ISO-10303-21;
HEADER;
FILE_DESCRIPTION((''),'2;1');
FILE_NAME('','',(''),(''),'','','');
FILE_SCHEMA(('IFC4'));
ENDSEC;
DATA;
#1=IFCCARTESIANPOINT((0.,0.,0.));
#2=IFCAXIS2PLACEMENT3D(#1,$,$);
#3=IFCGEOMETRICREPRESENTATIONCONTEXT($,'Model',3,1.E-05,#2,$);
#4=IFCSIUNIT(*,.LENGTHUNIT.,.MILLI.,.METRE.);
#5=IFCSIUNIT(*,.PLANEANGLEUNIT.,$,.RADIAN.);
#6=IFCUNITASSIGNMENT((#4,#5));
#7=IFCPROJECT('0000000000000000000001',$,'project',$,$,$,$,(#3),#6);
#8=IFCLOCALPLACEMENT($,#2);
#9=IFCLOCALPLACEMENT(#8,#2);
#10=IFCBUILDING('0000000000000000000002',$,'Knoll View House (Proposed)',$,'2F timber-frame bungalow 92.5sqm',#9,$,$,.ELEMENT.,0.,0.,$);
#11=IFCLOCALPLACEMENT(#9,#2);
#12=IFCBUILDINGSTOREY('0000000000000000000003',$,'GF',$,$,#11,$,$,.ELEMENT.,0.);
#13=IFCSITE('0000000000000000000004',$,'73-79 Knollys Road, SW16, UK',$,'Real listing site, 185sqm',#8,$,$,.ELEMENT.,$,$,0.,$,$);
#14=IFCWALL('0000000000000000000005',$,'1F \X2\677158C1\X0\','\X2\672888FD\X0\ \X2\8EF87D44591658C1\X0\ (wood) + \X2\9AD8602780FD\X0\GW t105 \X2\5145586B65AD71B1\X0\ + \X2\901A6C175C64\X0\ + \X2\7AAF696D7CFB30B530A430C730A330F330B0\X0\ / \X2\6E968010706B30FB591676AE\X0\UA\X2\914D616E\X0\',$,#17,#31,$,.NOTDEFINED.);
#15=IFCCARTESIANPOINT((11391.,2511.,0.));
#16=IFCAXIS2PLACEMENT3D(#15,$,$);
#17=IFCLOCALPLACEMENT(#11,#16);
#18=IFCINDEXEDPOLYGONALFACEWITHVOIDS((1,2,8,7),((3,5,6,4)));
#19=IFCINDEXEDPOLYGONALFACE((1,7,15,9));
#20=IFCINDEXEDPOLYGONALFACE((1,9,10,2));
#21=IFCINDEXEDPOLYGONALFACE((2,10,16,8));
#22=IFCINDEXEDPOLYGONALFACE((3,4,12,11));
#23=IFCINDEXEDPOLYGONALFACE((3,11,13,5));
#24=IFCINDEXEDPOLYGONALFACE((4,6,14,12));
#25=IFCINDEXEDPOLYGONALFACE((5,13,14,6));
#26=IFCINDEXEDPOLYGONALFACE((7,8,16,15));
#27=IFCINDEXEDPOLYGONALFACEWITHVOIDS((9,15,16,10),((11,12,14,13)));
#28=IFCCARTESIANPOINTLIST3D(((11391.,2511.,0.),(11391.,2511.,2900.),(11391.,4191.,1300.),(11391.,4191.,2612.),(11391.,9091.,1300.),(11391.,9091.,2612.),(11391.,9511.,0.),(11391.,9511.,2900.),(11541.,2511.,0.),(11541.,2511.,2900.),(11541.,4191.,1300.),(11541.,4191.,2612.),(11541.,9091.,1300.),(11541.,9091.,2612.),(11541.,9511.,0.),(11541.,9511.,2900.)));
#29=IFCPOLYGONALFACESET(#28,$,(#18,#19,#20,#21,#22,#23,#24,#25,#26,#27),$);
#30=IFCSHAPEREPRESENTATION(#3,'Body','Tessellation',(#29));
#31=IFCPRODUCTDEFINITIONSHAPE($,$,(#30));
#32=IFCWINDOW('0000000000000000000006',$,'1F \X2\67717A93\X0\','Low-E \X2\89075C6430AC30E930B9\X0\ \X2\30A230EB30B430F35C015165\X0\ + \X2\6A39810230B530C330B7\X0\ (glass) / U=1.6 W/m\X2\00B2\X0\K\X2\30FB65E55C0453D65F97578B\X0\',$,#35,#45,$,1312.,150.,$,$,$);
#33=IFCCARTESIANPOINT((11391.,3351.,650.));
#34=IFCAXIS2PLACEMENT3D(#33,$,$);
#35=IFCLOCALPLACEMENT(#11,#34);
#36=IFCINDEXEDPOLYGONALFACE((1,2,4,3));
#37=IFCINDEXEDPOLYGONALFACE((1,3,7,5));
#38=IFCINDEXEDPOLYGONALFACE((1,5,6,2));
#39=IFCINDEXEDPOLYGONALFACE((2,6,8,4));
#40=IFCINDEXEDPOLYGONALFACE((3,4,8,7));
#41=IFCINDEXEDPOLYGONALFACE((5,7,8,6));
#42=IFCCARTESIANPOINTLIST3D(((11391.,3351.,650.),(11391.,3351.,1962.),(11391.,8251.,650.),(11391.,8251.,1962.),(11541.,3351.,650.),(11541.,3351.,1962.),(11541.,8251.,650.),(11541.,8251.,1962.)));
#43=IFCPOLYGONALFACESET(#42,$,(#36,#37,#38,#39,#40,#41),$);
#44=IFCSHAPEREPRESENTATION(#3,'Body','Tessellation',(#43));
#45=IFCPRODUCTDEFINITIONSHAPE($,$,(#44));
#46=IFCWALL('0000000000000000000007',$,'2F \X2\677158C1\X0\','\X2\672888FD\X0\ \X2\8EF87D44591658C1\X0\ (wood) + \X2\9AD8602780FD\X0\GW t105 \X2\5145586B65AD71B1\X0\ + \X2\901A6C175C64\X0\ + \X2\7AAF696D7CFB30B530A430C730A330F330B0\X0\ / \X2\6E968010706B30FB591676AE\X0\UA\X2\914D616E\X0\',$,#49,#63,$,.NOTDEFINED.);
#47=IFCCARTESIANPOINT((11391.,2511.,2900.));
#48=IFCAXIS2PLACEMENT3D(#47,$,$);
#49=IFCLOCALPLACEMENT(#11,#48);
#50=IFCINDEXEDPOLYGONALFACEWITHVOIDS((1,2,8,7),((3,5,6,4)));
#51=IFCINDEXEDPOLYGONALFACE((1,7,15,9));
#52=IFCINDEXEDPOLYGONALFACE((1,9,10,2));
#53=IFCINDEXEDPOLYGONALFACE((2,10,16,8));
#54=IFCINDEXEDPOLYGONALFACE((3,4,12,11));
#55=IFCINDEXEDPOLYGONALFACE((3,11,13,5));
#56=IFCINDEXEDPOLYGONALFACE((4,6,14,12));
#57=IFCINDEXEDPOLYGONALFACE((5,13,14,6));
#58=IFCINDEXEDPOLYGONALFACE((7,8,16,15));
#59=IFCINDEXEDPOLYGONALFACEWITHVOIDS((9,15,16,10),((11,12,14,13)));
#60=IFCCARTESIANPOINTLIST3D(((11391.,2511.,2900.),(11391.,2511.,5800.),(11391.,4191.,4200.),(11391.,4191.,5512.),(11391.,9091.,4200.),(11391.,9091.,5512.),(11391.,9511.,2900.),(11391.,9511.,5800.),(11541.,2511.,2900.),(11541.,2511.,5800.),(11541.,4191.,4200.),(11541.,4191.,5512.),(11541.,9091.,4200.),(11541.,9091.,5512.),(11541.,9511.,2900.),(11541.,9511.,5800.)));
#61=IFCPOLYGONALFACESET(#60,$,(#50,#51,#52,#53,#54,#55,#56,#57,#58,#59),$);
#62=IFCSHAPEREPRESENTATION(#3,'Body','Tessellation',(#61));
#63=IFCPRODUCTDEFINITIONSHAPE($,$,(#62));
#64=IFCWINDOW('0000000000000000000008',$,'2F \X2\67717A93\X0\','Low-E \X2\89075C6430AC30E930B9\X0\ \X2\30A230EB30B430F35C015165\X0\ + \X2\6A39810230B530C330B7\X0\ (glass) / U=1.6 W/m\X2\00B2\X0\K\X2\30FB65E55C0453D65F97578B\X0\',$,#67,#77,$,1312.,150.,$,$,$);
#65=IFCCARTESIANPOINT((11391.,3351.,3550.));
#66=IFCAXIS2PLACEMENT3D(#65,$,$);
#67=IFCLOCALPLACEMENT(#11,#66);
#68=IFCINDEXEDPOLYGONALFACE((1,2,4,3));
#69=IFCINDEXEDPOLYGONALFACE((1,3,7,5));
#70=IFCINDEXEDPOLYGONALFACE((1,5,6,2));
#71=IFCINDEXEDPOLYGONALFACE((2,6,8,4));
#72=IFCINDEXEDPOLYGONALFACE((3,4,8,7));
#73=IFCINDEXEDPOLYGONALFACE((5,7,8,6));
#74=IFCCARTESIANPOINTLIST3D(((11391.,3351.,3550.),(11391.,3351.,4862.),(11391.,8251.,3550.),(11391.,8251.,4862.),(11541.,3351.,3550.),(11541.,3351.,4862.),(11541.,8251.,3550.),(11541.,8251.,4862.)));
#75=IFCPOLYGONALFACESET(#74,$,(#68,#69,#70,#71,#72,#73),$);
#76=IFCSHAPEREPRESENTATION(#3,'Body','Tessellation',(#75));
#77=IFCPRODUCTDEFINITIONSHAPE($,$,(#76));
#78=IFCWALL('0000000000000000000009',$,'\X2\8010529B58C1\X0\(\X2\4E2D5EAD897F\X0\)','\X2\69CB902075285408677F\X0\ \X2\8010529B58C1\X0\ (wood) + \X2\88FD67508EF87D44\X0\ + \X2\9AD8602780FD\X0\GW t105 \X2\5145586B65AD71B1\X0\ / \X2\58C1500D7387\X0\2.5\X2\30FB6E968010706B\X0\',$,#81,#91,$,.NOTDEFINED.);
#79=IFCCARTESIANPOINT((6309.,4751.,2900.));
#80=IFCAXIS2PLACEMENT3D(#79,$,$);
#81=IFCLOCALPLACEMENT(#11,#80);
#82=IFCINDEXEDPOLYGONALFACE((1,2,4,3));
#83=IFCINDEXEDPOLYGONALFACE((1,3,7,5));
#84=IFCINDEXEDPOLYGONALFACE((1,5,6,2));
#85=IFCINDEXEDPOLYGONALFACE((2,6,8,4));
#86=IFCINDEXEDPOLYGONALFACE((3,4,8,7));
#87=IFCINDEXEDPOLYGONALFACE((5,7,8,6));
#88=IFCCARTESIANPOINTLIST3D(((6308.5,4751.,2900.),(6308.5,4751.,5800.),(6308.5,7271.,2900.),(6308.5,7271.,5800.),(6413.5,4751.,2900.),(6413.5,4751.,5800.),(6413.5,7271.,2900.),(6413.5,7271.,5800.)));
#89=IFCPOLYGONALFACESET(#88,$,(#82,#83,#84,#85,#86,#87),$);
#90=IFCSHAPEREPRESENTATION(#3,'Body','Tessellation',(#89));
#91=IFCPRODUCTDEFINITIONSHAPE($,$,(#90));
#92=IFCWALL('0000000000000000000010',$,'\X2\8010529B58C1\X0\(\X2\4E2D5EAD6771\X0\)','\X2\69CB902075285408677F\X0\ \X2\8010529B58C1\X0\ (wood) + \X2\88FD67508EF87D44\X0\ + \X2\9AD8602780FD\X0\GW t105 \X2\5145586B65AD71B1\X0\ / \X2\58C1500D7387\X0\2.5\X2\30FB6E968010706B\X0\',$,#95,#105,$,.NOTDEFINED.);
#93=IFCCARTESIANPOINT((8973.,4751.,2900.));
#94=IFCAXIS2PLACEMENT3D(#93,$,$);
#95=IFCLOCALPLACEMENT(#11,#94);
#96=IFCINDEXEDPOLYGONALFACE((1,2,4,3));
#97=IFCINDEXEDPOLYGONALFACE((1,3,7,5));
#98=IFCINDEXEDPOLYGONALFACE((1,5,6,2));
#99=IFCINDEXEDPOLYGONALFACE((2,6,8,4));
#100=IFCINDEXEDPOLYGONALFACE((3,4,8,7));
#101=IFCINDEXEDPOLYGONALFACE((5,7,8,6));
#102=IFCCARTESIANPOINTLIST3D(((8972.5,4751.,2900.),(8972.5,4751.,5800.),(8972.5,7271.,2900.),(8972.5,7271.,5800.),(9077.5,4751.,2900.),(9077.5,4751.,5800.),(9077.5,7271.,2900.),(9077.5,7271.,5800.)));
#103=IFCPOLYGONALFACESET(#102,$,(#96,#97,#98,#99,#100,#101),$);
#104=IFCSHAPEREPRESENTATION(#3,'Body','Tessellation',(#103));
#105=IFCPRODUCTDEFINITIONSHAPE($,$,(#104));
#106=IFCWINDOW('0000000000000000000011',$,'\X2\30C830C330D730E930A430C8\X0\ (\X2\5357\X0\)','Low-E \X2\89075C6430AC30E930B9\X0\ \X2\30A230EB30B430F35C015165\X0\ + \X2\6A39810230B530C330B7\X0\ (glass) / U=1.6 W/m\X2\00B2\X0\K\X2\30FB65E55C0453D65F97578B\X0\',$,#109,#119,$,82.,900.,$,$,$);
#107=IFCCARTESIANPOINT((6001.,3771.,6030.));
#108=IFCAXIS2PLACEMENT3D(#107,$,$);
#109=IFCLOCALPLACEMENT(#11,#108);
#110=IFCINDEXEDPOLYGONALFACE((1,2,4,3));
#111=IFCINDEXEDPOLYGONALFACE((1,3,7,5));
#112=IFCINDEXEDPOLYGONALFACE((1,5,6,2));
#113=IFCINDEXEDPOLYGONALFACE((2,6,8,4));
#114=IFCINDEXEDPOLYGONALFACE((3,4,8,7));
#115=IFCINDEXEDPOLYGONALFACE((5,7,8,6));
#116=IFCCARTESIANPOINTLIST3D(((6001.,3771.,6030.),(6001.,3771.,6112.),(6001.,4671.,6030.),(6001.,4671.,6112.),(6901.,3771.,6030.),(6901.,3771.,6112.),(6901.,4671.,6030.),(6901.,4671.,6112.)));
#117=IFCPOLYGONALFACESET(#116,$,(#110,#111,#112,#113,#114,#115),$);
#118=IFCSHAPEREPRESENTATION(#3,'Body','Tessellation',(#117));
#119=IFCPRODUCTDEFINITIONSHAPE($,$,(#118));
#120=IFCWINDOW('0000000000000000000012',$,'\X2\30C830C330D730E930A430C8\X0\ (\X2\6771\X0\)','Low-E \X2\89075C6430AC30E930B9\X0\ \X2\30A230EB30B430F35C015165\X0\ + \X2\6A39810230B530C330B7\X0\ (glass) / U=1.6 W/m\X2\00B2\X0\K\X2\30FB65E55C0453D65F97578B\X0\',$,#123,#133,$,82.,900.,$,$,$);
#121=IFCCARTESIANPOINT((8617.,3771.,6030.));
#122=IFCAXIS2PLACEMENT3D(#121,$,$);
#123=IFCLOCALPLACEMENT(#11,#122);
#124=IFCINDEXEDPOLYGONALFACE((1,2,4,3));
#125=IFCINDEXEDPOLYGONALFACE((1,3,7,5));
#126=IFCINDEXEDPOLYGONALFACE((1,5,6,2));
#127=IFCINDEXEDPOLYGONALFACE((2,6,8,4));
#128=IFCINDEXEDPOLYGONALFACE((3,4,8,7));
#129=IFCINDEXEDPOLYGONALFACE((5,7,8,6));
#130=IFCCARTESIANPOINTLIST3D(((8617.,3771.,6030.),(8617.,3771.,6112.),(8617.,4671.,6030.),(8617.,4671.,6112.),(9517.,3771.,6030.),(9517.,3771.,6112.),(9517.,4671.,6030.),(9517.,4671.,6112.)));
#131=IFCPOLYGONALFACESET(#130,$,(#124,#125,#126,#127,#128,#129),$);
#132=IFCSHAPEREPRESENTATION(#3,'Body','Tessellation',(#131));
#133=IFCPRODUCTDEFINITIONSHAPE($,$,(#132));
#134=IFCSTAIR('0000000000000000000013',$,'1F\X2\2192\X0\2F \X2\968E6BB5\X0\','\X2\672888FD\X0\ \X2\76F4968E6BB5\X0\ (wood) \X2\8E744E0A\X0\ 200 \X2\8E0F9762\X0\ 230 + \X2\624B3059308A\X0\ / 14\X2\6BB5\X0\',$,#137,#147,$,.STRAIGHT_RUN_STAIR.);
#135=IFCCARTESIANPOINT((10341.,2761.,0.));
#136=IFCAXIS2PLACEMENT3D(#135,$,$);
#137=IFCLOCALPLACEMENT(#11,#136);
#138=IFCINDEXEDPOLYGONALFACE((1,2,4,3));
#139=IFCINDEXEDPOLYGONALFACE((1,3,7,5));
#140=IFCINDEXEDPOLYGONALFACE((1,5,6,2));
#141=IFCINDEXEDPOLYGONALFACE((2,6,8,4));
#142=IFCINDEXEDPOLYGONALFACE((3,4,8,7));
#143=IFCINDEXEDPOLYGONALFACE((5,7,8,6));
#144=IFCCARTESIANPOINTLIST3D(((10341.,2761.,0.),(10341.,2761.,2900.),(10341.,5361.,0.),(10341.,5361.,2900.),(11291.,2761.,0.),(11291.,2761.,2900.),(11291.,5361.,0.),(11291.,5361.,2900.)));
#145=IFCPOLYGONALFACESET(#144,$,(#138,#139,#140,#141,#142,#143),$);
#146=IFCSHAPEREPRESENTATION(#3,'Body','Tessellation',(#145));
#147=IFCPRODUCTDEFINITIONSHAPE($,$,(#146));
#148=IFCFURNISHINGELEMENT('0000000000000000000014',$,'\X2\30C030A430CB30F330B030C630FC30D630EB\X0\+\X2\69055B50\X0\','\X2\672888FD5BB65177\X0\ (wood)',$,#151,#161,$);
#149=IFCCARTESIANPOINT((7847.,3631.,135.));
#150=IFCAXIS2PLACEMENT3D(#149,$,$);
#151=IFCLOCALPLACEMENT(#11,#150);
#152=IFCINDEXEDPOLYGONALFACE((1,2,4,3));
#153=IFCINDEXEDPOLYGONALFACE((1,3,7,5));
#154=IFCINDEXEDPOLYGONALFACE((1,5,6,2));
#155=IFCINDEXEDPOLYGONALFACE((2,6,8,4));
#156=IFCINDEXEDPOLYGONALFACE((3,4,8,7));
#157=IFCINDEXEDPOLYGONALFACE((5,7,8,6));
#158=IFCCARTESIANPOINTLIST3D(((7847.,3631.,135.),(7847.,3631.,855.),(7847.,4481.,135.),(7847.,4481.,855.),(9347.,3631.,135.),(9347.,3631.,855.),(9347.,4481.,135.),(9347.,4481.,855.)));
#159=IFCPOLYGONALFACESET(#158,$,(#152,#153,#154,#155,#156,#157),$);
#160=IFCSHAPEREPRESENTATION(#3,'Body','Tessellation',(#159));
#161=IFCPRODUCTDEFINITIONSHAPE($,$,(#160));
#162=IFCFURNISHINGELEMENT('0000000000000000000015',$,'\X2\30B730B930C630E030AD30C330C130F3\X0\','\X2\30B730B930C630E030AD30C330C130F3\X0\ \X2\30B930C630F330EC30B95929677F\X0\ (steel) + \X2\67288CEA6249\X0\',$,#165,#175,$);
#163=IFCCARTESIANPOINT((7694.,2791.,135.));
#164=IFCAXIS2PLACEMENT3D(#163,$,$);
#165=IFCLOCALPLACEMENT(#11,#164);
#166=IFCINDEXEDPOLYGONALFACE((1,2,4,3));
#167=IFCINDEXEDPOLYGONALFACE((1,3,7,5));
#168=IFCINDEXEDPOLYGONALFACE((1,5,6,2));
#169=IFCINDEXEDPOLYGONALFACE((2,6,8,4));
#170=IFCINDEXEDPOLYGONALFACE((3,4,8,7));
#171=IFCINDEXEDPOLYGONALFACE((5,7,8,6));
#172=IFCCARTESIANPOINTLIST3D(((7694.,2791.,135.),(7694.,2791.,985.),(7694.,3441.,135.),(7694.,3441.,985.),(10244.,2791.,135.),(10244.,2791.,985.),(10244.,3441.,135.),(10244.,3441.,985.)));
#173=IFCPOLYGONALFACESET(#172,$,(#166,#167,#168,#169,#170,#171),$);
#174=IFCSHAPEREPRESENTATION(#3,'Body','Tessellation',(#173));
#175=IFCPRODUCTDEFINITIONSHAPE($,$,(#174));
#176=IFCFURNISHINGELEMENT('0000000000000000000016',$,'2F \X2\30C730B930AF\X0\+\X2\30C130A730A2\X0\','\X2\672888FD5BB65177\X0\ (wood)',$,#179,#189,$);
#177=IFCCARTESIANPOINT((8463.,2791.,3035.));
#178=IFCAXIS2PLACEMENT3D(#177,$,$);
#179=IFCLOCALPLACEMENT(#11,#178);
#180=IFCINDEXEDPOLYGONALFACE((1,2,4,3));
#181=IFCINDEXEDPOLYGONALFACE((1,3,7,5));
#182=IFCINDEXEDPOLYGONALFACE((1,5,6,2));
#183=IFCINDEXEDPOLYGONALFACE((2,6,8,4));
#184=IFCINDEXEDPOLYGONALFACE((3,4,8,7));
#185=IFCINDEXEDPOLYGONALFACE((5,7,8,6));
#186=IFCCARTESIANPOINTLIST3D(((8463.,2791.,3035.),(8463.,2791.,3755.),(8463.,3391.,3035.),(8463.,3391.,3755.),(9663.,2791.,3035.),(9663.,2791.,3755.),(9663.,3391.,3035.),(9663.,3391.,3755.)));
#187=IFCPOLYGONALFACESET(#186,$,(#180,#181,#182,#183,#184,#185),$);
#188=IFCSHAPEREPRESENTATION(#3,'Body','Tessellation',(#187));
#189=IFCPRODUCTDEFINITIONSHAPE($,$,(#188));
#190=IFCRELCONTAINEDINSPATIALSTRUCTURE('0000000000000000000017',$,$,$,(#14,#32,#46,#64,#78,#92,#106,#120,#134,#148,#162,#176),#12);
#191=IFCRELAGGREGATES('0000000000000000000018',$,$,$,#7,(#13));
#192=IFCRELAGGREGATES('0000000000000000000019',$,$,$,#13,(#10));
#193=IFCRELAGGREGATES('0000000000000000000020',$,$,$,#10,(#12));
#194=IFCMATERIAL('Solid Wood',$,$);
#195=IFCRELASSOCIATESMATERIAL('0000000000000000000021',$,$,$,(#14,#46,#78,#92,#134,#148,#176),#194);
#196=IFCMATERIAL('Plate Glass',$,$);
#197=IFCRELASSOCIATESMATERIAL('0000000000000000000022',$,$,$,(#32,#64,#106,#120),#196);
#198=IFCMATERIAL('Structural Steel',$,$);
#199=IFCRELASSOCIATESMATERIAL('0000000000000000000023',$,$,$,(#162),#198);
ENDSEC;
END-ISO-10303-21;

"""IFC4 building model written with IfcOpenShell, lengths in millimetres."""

from ifc_helpers import new_model, si_unit, frame, frame_2d, origin, place, context, project, spatial, rectangle, extrude, material, element, fill, save


model = new_model("IFC4")

# Units and contexts
model_context = context("Model", 3, precision=1e-05, world=origin())
ifc_project = project(units=[si_unit("LENGTHUNIT", "METRE", prefix="MILLI"), si_unit("PLANEANGLEUNIT", "RADIAN")], contexts=[model_context])

# Site, building, storey
site_placement = place(None, origin())
site = spatial("IfcSite", under=ifc_project, at=site_placement, Name="73-79 Knollys Road, SW16, UK", ObjectType="Real listing site, 185sqm", CompositionType="ELEMENT", RefElevation=0.0)
building_placement = place(site_placement, origin())
building = spatial("IfcBuilding", under=site, at=building_placement, Name="Knoll View House (Proposed)", ObjectType="2F timber-frame bungalow 92.5sqm", CompositionType="ELEMENT", ElevationOfRefHeight=0.0, ElevationOfTerrain=0.0)
storey_placement = place(building_placement, origin())
storey = spatial("IfcBuildingStorey", under=building, at=storey_placement, Name="GF", CompositionType="ELEMENT", Elevation=0.0)

# Shared definitions
ifc_material_1 = material(Name="Solid Wood")

# Wall, opening, window
wall_1_placement = place(storey_placement, frame((11391.0, 2511.0, 0.0)))
wall_1 = element("IfcWall", 1, at=wall_1_placement, inside=storey, material=ifc_material_1, Name="1F 東壁", Description="木製 軸組外壁 (wood) + 高性能GW t105 充填断熱 + 通気層 + 窯業系サイディング / 準耐火・外皮UA配慮", PredefinedType="NOTDEFINED", context=model_context, shape_type="SweptSolid", body=[
    extrude(rectangle(XDim=150.0, YDim=7000.0, at=frame_2d((75.0, 3500.0))), frame((11391.0, 2511.0, 0.0)), (0.0, 0.0, 1.0), 2900.0),
])
opening_1_placement = place(storey_placement, frame((11391.0, 3351.0, 650.0)))
opening_1 = element("IfcOpeningElement", 2, at=opening_1_placement, cuts=wall_1, PredefinedType="NOTDEFINED", context=model_context, shape_type="SweptSolid", body=[
    extrude(rectangle(XDim=150.0, YDim=4900.0, at=frame_2d((75.0, 2450.0))), frame((11391.0, 3351.0, 650.0)), (0.0, 0.0, 1.0), 1312.0),
])
ifc_material_2 = material(Name="Plate Glass")
window_1_placement = place(storey_placement, frame((11391.0, 3351.0, 650.0)))
window_1 = element("IfcWindow", 3, at=window_1_placement, inside=storey, material=ifc_material_2, Name="1F 東窓", Description="Low-E 複層ガラス アルゴン封入 + 樹脂サッシ (glass) / U=1.6 W/m²K・日射取得型", OverallHeight=1312.0, OverallWidth=150.0, context=model_context, shape_type="SweptSolid", body=[
    extrude(rectangle(XDim=150.0, YDim=4900.0, at=frame_2d((75.0, 2450.0))), frame((11391.0, 3351.0, 650.0)), (0.0, 0.0, 1.0), 1312.0),
])
fill(opening_1, window_1)

# Wall, opening, window
wall_2_placement = place(storey_placement, frame((11391.0, 2511.0, 2900.0)))
wall_2 = element("IfcWall", 4, at=wall_2_placement, inside=storey, material=ifc_material_1, Name="2F 東壁", Description="木製 軸組外壁 (wood) + 高性能GW t105 充填断熱 + 通気層 + 窯業系サイディング / 準耐火・外皮UA配慮", PredefinedType="NOTDEFINED", context=model_context, shape_type="SweptSolid", body=[
    extrude(rectangle(XDim=150.0, YDim=7000.0, at=frame_2d((75.0, 3500.0))), frame((11391.0, 2511.0, 2900.0)), (0.0, 0.0, 1.0), 2900.0),
])
opening_2_placement = place(storey_placement, frame((11391.0, 3351.0, 3550.0)))
opening_2 = element("IfcOpeningElement", 5, at=opening_2_placement, cuts=wall_2, PredefinedType="NOTDEFINED", context=model_context, shape_type="SweptSolid", body=[
    extrude(rectangle(XDim=150.0, YDim=4900.0, at=frame_2d((75.0, 2450.0))), frame((11391.0, 3351.0, 3550.0)), (0.0, 0.0, 1.0), 1312.0),
])
window_2_placement = place(storey_placement, frame((11391.0, 3351.0, 3550.0)))
window_2 = element("IfcWindow", 6, at=window_2_placement, inside=storey, material=ifc_material_2, Name="2F 東窓", Description="Low-E 複層ガラス アルゴン封入 + 樹脂サッシ (glass) / U=1.6 W/m²K・日射取得型", OverallHeight=1312.0, OverallWidth=150.0, context=model_context, shape_type="SweptSolid", body=[
    extrude(rectangle(XDim=150.0, YDim=4900.0, at=frame_2d((75.0, 2450.0))), frame((11391.0, 3351.0, 3550.0)), (0.0, 0.0, 1.0), 1312.0),
])
fill(opening_2, window_2)

# Walls
wall_3_placement = place(storey_placement, frame((6309.0, 4751.0, 2900.0)))
element("IfcWall", 7, at=wall_3_placement, inside=storey, material=ifc_material_1, Name="耐力壁(中庭西)", Description="構造用合板 耐力壁 (wood) + 製材軸組 + 高性能GW t105 充填断熱 / 壁倍率2.5・準耐火", PredefinedType="NOTDEFINED", context=model_context, shape_type="SweptSolid", body=[
    extrude(rectangle(XDim=105.0, YDim=2520.0, at=frame_2d((52.0, 1260.0))), frame((6309.0, 4751.0, 2900.0)), (0.0, 0.0, 1.0), 2900.0),
])
wall_4_placement = place(storey_placement, frame((8973.0, 4751.0, 2900.0)))
element("IfcWall", 8, at=wall_4_placement, inside=storey, material=ifc_material_1, Name="耐力壁(中庭東)", Description="構造用合板 耐力壁 (wood) + 製材軸組 + 高性能GW t105 充填断熱 / 壁倍率2.5・準耐火", PredefinedType="NOTDEFINED", context=model_context, shape_type="SweptSolid", body=[
    extrude(rectangle(XDim=105.0, YDim=2520.0, at=frame_2d((52.0, 1260.0))), frame((8973.0, 4751.0, 2900.0)), (0.0, 0.0, 1.0), 2900.0),
])

# Windows
window_3_placement = place(storey_placement, frame((6001.0, 3771.0, 6030.0)))
element("IfcWindow", 9, at=window_3_placement, inside=storey, material=ifc_material_2, Name="トップライト (南)", Description="Low-E 複層ガラス アルゴン封入 + 樹脂サッシ (glass) / U=1.6 W/m²K・日射取得型", OverallHeight=82.0, OverallWidth=900.0, context=model_context, shape_type="SweptSolid", body=[
    extrude(rectangle(XDim=900.0, YDim=900.0, at=frame_2d((450.0, 450.0))), frame((6001.0, 3771.0, 6030.0)), (0.0, 0.0, 1.0), 82.0),
])
window_4_placement = place(storey_placement, frame((8617.0, 3771.0, 6030.0)))
element("IfcWindow", 10, at=window_4_placement, inside=storey, material=ifc_material_2, Name="トップライト (東)", Description="Low-E 複層ガラス アルゴン封入 + 樹脂サッシ (glass) / U=1.6 W/m²K・日射取得型", OverallHeight=82.0, OverallWidth=900.0, context=model_context, shape_type="SweptSolid", body=[
    extrude(rectangle(XDim=900.0, YDim=900.0, at=frame_2d((450.0, 450.0))), frame((8617.0, 3771.0, 6030.0)), (0.0, 0.0, 1.0), 82.0),
])

# Stair
stair_placement = place(storey_placement, frame((10341.0, 2761.0, 0.0)))
element("IfcStair", 11, at=stair_placement, inside=storey, material=ifc_material_1, Name="1F→2F 階段", Description="木製 直階段 (wood) 蹴上 200 踏面 230 + 手すり / 14段", PredefinedType="STRAIGHT_RUN_STAIR", context=model_context, shape_type="SweptSolid", body=[
    extrude(rectangle(XDim=950.0, YDim=2600.0, at=frame_2d((475.0, 1300.0))), frame((10341.0, 2761.0, 0.0)), (0.0, 0.0, 1.0), 2900.0),
])

# Furnishing elements
furnishing_1_placement = place(storey_placement, frame((7847.0, 3631.0, 135.0)))
element("IfcFurnishingElement", 12, at=furnishing_1_placement, inside=storey, material=ifc_material_1, Name="ダイニングテーブル+椅子", Description="木製家具 (wood)", context=model_context, shape_type="SweptSolid", body=[
    extrude(rectangle(XDim=1500.0, YDim=850.0, at=frame_2d((750.0, 425.0))), frame((7847.0, 3631.0, 135.0)), (0.0, 0.0, 1.0), 720.0),
])
ifc_material_3 = material(Name="Structural Steel")
furnishing_2_placement = place(storey_placement, frame((7694.0, 2791.0, 135.0)))
element("IfcFurnishingElement", 13, at=furnishing_2_placement, inside=storey, material=ifc_material_3, Name="システムキッチン", Description="システムキッチン ステンレス天板 (steel) + 木質扉", context=model_context, shape_type="SweptSolid", body=[
    extrude(rectangle(XDim=2550.0, YDim=650.0, at=frame_2d((1275.0, 325.0))), frame((7694.0, 2791.0, 135.0)), (0.0, 0.0, 1.0), 850.0),
])
furnishing_3_placement = place(storey_placement, frame((8463.0, 2791.0, 3035.0)))
element("IfcFurnishingElement", 14, at=furnishing_3_placement, inside=storey, material=ifc_material_1, Name="2F デスク+チェア", Description="木製家具 (wood)", context=model_context, shape_type="SweptSolid", body=[
    extrude(rectangle(XDim=1200.0, YDim=600.0, at=frame_2d((600.0, 300.0))), frame((8463.0, 2791.0, 3035.0)), (0.0, 0.0, 1.0), 720.0),
])

save(model, "model.ifc")
